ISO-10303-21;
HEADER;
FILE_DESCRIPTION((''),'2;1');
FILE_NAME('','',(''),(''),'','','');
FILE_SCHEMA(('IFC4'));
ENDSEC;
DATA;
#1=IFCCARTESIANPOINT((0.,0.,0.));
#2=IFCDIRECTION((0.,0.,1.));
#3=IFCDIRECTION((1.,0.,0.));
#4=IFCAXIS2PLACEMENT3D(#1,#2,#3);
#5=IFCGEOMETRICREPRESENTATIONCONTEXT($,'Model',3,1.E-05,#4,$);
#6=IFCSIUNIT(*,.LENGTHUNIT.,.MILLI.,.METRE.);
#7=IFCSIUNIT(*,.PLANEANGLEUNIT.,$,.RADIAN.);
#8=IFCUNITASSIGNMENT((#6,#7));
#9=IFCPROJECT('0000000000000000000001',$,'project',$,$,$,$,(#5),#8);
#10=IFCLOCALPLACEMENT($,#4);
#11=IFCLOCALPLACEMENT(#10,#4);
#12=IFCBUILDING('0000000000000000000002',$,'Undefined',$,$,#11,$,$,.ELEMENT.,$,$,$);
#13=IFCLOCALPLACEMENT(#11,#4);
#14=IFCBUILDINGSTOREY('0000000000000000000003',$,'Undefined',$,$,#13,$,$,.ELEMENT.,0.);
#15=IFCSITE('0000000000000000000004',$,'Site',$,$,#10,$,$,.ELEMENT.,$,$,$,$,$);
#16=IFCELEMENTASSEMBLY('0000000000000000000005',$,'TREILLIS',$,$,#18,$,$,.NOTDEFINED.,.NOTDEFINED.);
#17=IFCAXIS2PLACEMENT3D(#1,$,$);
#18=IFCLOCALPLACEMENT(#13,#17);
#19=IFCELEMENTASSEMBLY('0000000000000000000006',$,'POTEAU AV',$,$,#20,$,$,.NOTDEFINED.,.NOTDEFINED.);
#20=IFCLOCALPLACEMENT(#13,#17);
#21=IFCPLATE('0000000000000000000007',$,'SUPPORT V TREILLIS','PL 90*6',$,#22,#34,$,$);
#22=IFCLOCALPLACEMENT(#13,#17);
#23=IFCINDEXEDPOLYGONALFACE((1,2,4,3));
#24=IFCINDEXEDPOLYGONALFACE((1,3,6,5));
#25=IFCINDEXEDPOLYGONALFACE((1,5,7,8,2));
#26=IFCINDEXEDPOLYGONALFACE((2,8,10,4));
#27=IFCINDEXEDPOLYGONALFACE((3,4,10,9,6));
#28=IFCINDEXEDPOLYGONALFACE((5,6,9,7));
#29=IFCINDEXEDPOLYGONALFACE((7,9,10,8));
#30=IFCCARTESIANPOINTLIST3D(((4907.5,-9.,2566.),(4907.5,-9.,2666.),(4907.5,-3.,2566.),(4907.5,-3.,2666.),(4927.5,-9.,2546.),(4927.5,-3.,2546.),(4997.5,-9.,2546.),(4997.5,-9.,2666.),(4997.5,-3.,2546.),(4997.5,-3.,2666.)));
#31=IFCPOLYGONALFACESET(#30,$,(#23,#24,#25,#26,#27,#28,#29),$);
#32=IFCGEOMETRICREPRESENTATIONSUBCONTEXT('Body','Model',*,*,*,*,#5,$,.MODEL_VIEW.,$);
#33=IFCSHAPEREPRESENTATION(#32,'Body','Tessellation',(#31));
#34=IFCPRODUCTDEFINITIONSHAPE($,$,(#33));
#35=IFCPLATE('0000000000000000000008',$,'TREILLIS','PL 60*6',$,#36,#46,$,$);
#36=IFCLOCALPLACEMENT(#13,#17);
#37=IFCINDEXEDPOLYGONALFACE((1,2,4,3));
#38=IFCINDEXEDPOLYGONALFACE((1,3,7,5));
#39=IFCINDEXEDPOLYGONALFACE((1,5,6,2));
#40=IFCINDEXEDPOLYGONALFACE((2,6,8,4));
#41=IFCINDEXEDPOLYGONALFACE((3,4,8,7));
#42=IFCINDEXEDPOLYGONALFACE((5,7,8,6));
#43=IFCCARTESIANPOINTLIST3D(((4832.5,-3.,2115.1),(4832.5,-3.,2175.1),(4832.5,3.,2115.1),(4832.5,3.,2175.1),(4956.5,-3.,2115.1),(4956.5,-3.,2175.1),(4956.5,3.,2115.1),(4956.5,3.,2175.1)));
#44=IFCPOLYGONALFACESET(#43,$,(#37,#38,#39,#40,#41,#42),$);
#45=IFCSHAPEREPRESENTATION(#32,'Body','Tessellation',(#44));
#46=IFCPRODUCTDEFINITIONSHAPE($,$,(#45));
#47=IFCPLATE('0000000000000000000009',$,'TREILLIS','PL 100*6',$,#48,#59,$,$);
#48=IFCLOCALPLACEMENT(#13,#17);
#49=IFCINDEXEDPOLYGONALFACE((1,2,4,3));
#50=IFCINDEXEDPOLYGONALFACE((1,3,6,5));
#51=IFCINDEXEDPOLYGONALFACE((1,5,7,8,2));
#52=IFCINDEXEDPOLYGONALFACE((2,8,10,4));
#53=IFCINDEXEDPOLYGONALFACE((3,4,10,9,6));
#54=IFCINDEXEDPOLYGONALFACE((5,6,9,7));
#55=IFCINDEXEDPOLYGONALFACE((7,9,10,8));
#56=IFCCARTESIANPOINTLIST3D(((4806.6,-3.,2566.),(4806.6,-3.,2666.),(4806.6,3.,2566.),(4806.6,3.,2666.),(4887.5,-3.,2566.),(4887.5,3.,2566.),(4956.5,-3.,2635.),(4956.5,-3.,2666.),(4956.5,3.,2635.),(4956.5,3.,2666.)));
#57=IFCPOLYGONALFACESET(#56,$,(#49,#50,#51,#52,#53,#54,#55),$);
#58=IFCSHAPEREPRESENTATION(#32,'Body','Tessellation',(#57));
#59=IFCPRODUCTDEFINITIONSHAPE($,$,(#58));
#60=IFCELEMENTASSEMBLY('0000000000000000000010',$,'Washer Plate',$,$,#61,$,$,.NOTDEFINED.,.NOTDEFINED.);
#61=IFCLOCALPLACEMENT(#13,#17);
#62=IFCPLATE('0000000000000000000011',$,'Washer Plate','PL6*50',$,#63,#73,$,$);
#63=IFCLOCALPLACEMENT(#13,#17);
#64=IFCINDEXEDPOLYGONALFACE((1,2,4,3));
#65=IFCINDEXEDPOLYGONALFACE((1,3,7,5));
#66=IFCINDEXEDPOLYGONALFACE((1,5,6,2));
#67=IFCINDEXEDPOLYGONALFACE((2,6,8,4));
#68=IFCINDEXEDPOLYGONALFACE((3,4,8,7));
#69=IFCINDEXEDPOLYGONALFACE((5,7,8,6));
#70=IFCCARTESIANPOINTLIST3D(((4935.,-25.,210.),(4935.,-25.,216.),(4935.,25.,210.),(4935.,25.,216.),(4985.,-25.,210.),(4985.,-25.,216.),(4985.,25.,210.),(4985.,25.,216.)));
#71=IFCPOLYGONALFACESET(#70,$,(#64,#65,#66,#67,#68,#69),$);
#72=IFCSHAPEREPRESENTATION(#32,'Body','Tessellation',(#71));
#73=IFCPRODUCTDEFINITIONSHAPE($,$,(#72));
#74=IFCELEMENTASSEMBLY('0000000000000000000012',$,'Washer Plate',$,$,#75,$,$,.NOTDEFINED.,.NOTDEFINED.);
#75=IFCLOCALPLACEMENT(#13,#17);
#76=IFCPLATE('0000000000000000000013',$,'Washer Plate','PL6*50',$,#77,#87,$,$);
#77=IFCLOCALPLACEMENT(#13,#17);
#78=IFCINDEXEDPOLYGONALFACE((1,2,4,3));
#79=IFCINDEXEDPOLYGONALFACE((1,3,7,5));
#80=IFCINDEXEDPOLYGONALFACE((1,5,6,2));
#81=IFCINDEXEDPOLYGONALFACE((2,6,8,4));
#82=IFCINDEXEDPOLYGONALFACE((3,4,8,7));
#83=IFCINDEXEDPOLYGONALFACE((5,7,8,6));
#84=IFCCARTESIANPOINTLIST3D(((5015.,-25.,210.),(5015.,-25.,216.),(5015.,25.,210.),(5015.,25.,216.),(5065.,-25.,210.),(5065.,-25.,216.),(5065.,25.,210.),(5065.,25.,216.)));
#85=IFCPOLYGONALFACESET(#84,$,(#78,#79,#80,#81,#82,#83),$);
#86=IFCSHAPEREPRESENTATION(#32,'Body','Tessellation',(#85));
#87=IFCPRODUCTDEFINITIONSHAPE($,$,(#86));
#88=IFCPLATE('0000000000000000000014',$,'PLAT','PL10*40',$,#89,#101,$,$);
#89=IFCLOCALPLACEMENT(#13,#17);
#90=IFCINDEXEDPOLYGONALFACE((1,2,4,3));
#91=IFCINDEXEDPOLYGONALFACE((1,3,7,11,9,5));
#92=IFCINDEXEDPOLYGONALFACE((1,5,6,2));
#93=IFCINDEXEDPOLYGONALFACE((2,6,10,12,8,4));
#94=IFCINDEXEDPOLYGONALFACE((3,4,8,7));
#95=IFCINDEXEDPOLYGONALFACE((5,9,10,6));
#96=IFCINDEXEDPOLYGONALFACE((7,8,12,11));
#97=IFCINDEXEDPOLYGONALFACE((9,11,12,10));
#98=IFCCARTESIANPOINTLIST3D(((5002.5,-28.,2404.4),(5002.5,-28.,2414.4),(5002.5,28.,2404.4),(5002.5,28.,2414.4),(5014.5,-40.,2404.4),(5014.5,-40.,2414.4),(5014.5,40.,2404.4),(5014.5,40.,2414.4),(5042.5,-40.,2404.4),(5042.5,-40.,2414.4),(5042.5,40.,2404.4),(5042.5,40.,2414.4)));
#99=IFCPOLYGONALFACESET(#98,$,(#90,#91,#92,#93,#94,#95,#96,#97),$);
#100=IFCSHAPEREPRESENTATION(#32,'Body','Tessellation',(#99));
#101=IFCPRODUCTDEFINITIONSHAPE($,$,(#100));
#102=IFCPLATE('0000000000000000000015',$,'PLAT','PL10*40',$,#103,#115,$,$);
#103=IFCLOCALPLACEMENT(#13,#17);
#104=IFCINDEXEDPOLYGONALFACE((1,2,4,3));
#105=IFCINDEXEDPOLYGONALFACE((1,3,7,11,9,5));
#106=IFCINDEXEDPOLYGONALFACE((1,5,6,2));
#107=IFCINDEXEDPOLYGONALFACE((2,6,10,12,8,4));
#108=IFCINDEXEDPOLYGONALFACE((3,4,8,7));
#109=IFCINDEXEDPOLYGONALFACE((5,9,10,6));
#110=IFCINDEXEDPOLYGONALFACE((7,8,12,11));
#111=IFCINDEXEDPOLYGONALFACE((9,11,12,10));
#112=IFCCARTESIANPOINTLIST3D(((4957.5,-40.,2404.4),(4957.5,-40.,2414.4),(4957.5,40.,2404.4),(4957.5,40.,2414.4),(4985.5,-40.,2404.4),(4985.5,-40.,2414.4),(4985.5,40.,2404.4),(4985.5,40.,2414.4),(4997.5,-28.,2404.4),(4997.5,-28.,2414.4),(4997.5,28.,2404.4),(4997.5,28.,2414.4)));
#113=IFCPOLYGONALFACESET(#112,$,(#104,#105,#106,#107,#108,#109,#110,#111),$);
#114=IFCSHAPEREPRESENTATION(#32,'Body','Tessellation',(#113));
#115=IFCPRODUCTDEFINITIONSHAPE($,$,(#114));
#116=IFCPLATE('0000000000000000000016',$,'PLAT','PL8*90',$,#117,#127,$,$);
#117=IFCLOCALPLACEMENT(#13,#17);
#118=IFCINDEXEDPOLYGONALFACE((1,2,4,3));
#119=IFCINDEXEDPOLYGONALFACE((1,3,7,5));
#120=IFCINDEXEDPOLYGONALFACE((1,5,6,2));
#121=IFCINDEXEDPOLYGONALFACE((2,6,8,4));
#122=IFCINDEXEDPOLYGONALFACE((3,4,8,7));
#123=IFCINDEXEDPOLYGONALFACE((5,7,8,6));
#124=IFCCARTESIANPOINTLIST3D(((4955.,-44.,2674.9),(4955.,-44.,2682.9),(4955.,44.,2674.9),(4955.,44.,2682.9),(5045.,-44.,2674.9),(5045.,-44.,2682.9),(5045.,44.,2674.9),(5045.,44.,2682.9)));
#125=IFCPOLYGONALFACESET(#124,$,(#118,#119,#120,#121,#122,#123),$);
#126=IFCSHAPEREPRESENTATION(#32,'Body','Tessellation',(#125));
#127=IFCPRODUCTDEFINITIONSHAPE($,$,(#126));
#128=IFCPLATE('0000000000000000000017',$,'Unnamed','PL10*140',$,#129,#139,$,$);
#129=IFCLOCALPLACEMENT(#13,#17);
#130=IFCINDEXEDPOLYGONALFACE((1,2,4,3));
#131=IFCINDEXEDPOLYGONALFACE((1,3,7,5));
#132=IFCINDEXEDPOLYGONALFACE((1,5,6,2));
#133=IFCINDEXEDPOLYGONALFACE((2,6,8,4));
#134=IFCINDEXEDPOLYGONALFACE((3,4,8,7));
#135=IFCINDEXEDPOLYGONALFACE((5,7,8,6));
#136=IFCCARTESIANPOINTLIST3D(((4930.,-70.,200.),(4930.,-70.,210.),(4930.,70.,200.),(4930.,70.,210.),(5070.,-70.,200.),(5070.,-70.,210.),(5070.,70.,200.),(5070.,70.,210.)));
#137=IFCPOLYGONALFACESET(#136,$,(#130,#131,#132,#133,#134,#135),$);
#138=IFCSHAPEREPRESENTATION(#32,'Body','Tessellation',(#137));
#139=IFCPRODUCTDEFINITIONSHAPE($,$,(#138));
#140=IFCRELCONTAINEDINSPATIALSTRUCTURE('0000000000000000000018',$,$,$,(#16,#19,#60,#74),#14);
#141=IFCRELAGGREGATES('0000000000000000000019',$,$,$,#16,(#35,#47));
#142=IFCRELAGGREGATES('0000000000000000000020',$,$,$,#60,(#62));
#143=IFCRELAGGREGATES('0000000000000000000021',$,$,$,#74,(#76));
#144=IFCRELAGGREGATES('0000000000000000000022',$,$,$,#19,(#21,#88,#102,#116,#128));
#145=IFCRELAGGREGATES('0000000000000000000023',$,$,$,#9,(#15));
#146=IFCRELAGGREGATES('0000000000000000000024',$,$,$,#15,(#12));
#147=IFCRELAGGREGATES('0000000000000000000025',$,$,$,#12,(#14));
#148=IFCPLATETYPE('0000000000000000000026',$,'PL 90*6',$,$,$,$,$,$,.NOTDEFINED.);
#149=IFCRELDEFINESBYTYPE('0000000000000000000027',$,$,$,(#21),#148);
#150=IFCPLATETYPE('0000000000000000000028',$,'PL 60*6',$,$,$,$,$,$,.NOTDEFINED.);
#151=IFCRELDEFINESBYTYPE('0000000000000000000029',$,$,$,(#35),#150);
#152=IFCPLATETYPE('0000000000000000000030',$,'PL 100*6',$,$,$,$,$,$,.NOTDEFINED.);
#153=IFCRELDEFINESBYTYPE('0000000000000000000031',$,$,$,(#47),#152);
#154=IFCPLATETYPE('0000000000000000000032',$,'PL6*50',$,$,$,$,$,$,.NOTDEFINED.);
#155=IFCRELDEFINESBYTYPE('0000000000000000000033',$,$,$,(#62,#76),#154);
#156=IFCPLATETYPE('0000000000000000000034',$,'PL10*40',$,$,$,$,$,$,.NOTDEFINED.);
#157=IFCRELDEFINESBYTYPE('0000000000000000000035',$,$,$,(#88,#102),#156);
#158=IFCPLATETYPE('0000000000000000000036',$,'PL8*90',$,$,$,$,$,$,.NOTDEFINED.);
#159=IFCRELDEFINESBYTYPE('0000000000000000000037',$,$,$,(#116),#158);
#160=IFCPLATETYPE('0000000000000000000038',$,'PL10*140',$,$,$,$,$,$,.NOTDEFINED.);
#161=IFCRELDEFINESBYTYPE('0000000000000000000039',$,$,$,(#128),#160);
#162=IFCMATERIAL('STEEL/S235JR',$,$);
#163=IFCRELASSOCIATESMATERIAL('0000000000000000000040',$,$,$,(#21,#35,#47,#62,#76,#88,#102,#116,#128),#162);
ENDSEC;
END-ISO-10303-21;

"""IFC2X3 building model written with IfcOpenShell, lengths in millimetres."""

from ifc_helpers import new_model, si_unit, frame, origin_with_axes, place, context, subcontext, project, spatial, polyline, outline, extrude, clip, halfspace, material, type_object, element, aggregate, save


model = new_model("IFC2X3")

# Units and contexts
model_context = context("Model", 3, precision=1e-05, world=origin_with_axes())
body_context = subcontext(model_context, "Body", "Model", "MODEL_VIEW")
ifc_project = project(units=[si_unit("LENGTHUNIT", "METRE", prefix="MILLI"), si_unit("PLANEANGLEUNIT", "RADIAN")], contexts=[model_context])

# Site, building, storey
site_placement = place(None, origin_with_axes())
site = spatial("IfcSite", under=ifc_project, at=site_placement, Name="Site", CompositionType="ELEMENT")
building_placement = place(site_placement, origin_with_axes())
building = spatial("IfcBuilding", under=site, at=building_placement, Name="Undefined", CompositionType="ELEMENT")
storey_placement = place(building_placement, origin_with_axes())
storey = spatial("IfcBuildingStorey", under=building, at=storey_placement, Name="Undefined", CompositionType="ELEMENT", Elevation=0.0)

# Element assemblies
ifc_material_1 = material(Name="STEEL/S235JR")
assembly_1_placement = place(storey_placement, origin_with_axes())
assembly_1 = element("IfcElementAssembly", 1, at=assembly_1_placement, inside=storey, Name="TREILLIS", AssemblyPlace="NOTDEFINED", PredefinedType="NOTDEFINED")
assembly_2_placement = place(storey_placement, origin_with_axes())
assembly_2 = element("IfcElementAssembly", 2, at=assembly_2_placement, inside=storey, Name="POTEAU AV", AssemblyPlace="NOTDEFINED", PredefinedType="NOTDEFINED")

# Plates
plate_type_1 = type_object("IfcPlateType", Name="PL 90*6", PredefinedType="NOTDEFINED")
plate_1_placement = place(assembly_2_placement, frame((4952.5, -6.0, 2666.0), z_axis=(0.0, 1.0, 0.0), x_axis=(0.0, 0.0, -1.0)))
plate_1 = element("IfcPlate", 3, at=plate_1_placement, type_object=plate_type_1, material=ifc_material_1, Name="SUPPORT V TREILLIS", Description="PL 90*6", context=body_context, shape_type="Clipping", body=[
    clip(extrude(outline(polyline([(120.0, 25.0), (120.0, -45.0), (0.0, -45.0), (0.0, 45.0), (100.0, 45.0), (120.0, 25.0)])), frame((0.0, 0.0, -3.0), z_axis=(0.0, 0.0, 1.0), x_axis=(1.0, 0.0, 0.0)), (0.0, 0.0, 1.0), 6.0), halfspace(frame((190.0, -45.0, 3.0), z_axis=(0.707107, 0.707107, 0.0), x_axis=(-0.707107, 0.707107, 0.0)), False)),
])
plate_type_2 = type_object("IfcPlateType", Name="PL 60*6", PredefinedType="NOTDEFINED")
plate_2_placement = place(assembly_1_placement, frame((4956.5, 0.0, 2145.1), z_axis=(0.0, 1.0, 0.0), x_axis=(-1.0, 0.0, 0.0)))
plate_2 = element("IfcPlate", 4, at=plate_2_placement, type_object=plate_type_2, material=ifc_material_1, Name="TREILLIS", Description="PL 60*6", context=body_context, shape_type="SweptSolid", body=[
    extrude(outline(polyline([(124.0, -30.0), (0.0, -30.0), (0.0, 30.0), (124.0, 30.0), (124.0, -30.0)])), frame((0.0, 0.0, -3.0), z_axis=(0.0, 0.0, 1.0), x_axis=(1.0, 0.0, 0.0)), (0.0, 0.0, 1.0), 6.0),
])
plate_type_3 = type_object("IfcPlateType", Name="PL 100*6", PredefinedType="NOTDEFINED")
plate_3_placement = place(assembly_1_placement, frame((4956.5, 0.0, 2616.0), z_axis=(0.0, 1.0, 0.0), x_axis=(-1.0, 0.0, 0.0)))
plate_3 = element("IfcPlate", 5, at=plate_3_placement, type_object=plate_type_3, material=ifc_material_1, Name="TREILLIS", Description="PL 100*6", context=body_context, shape_type="Clipping", body=[
    clip(extrude(outline(polyline([(69.0, -50.0), (0.0, 19.0), (0.0, 50.0), (149.9, 50.0), (149.9, -50.0), (69.0, -50.0)])), frame((0.0, 0.0, -3.0), z_axis=(0.0, 0.0, 1.0), x_axis=(1.0, 0.0, 0.0)), (0.0, 0.0, 1.0), 6.0), halfspace(frame((69.0, -50.0, -3.0), z_axis=(-0.707107, -0.707107, 0.0), x_axis=(-0.707107, 0.707107, 0.0)), False)),
])
aggregate(assembly_1, [plate_2, plate_3])

# Element assemblies, plates
assembly_3_placement = place(storey_placement, origin_with_axes())
assembly_3 = element("IfcElementAssembly", 6, at=assembly_3_placement, inside=storey, Name="Washer Plate", AssemblyPlace="NOTDEFINED", PredefinedType="NOTDEFINED")
plate_type_4 = type_object("IfcPlateType", Name="PL6*50", PredefinedType="NOTDEFINED")
plate_4_placement = place(assembly_3_placement, frame((4985.0, 25.0, 213.0), z_axis=(0.0, 0.0, -1.0), x_axis=(0.0, -1.0, 0.0)))
plate_4 = element("IfcPlate", 7, at=plate_4_placement, type_object=plate_type_4, material=ifc_material_1, Name="Washer Plate", Description="PL6*50", context=body_context, shape_type="SweptSolid", body=[
    extrude(outline(polyline([(0.0, 0.0), (50.0, 0.0), (50.0, 50.0), (0.0, 50.0), (0.0, 0.0)])), frame((0.0, 0.0, -3.0), z_axis=(0.0, 0.0, 1.0), x_axis=(1.0, 0.0, 0.0)), (0.0, 0.0, 1.0), 6.0),
])
assembly_4_placement = place(storey_placement, origin_with_axes())
assembly_4 = element("IfcElementAssembly", 8, at=assembly_4_placement, inside=storey, Name="Washer Plate", AssemblyPlace="NOTDEFINED", PredefinedType="NOTDEFINED")
plate_5_placement = place(assembly_4_placement, frame((5065.0, 25.0, 213.0), z_axis=(0.0, 0.0, -1.0), x_axis=(0.0, -1.0, 0.0)))
plate_5 = element("IfcPlate", 9, at=plate_5_placement, type_object=plate_type_4, material=ifc_material_1, Name="Washer Plate", Description="PL6*50", context=body_context, shape_type="SweptSolid", body=[
    extrude(outline(polyline([(0.0, 0.0), (50.0, 0.0), (50.0, 50.0), (0.0, 50.0), (0.0, 0.0)])), frame((0.0, 0.0, -3.0), z_axis=(0.0, 0.0, 1.0), x_axis=(1.0, 0.0, 0.0)), (0.0, 0.0, 1.0), 6.0),
])

# Plates
plate_type_5 = type_object("IfcPlateType", Name="PL10*40", PredefinedType="NOTDEFINED")
plate_6_placement = place(assembly_2_placement, frame((5042.5, 40.0, 2409.4), z_axis=(0.0, 0.0, 1.0), x_axis=(-1.0, 0.0, 0.0)))
plate_6 = element("IfcPlate", 10, at=plate_6_placement, type_object=plate_type_5, material=ifc_material_1, Name="PLAT", Description="PL10*40", context=body_context, shape_type="SweptSolid", body=[
    extrude(outline(polyline([(0.0, 0.0), (28.0, 0.0), (40.0, 12.0), (40.0, 68.0), (28.0, 80.0), (0.0, 80.0), (0.0, 0.0)])), frame((0.0, 0.0, -5.0), z_axis=(0.0, 0.0, 1.0), x_axis=(1.0, 0.0, 0.0)), (0.0, 0.0, 1.0), 10.0),
])
plate_7_placement = place(assembly_2_placement, frame((4957.5, 40.0, 2409.4), z_axis=(0.0, 0.0, -1.0), x_axis=(1.0, 0.0, 0.0)))
plate_7 = element("IfcPlate", 11, at=plate_7_placement, type_object=plate_type_5, material=ifc_material_1, Name="PLAT", Description="PL10*40", context=body_context, shape_type="SweptSolid", body=[
    extrude(outline(polyline([(0.0, 0.0), (28.0, 0.0), (40.0, 12.0), (40.0, 68.0), (28.0, 80.0), (0.0, 80.0), (0.0, 0.0)])), frame((0.0, 0.0, -5.0), z_axis=(0.0, 0.0, 1.0), x_axis=(1.0, 0.0, 0.0)), (0.0, 0.0, 1.0), 10.0),
])
plate_type_6 = type_object("IfcPlateType", Name="PL8*90", PredefinedType="NOTDEFINED")
plate_8_placement = place(assembly_2_placement, frame((5000.0, -44.0, 2678.9), z_axis=(0.0, 0.0, -1.0), x_axis=(0.0, 1.0, 0.0)))
plate_8 = element("IfcPlate", 12, at=plate_8_placement, type_object=plate_type_6, material=ifc_material_1, Name="PLAT", Description="PL8*90", context=body_context, shape_type="SweptSolid", body=[
    extrude(outline(polyline([(0.0, -45.0), (0.0, 45.0), (88.0, 45.0), (88.0, -45.0), (0.0, -45.0)])), frame((0.0, 0.0, -4.0), z_axis=(0.0, 0.0, 1.0), x_axis=(1.0, 0.0, 0.0)), (0.0, 0.0, 1.0), 8.0),
])
plate_type_7 = type_object("IfcPlateType", Name="PL10*140", PredefinedType="NOTDEFINED")
plate_9_placement = place(assembly_2_placement, frame((5000.0, -70.0, 205.0), z_axis=(0.0, 0.0, 1.0), x_axis=(0.0, 1.0, 0.0)))
plate_9 = element("IfcPlate", 13, at=plate_9_placement, type_object=plate_type_7, material=ifc_material_1, Name="Unnamed", Description="PL10*140", context=body_context, shape_type="SweptSolid", body=[
    extrude(outline(polyline([(0.0, 70.0), (140.0, 70.0), (140.0, -70.0), (0.0, -70.0), (0.0, 70.0)])), frame((0.0, 0.0, -5.0), z_axis=(0.0, 0.0, 1.0), x_axis=(1.0, 0.0, 0.0)), (0.0, 0.0, 1.0), 10.0),
])

aggregate(assembly_3, [plate_4])
aggregate(assembly_4, [plate_5])
aggregate(assembly_2, [plate_1, plate_6, plate_7, plate_8, plate_9])

save(model, "model.ifc")
